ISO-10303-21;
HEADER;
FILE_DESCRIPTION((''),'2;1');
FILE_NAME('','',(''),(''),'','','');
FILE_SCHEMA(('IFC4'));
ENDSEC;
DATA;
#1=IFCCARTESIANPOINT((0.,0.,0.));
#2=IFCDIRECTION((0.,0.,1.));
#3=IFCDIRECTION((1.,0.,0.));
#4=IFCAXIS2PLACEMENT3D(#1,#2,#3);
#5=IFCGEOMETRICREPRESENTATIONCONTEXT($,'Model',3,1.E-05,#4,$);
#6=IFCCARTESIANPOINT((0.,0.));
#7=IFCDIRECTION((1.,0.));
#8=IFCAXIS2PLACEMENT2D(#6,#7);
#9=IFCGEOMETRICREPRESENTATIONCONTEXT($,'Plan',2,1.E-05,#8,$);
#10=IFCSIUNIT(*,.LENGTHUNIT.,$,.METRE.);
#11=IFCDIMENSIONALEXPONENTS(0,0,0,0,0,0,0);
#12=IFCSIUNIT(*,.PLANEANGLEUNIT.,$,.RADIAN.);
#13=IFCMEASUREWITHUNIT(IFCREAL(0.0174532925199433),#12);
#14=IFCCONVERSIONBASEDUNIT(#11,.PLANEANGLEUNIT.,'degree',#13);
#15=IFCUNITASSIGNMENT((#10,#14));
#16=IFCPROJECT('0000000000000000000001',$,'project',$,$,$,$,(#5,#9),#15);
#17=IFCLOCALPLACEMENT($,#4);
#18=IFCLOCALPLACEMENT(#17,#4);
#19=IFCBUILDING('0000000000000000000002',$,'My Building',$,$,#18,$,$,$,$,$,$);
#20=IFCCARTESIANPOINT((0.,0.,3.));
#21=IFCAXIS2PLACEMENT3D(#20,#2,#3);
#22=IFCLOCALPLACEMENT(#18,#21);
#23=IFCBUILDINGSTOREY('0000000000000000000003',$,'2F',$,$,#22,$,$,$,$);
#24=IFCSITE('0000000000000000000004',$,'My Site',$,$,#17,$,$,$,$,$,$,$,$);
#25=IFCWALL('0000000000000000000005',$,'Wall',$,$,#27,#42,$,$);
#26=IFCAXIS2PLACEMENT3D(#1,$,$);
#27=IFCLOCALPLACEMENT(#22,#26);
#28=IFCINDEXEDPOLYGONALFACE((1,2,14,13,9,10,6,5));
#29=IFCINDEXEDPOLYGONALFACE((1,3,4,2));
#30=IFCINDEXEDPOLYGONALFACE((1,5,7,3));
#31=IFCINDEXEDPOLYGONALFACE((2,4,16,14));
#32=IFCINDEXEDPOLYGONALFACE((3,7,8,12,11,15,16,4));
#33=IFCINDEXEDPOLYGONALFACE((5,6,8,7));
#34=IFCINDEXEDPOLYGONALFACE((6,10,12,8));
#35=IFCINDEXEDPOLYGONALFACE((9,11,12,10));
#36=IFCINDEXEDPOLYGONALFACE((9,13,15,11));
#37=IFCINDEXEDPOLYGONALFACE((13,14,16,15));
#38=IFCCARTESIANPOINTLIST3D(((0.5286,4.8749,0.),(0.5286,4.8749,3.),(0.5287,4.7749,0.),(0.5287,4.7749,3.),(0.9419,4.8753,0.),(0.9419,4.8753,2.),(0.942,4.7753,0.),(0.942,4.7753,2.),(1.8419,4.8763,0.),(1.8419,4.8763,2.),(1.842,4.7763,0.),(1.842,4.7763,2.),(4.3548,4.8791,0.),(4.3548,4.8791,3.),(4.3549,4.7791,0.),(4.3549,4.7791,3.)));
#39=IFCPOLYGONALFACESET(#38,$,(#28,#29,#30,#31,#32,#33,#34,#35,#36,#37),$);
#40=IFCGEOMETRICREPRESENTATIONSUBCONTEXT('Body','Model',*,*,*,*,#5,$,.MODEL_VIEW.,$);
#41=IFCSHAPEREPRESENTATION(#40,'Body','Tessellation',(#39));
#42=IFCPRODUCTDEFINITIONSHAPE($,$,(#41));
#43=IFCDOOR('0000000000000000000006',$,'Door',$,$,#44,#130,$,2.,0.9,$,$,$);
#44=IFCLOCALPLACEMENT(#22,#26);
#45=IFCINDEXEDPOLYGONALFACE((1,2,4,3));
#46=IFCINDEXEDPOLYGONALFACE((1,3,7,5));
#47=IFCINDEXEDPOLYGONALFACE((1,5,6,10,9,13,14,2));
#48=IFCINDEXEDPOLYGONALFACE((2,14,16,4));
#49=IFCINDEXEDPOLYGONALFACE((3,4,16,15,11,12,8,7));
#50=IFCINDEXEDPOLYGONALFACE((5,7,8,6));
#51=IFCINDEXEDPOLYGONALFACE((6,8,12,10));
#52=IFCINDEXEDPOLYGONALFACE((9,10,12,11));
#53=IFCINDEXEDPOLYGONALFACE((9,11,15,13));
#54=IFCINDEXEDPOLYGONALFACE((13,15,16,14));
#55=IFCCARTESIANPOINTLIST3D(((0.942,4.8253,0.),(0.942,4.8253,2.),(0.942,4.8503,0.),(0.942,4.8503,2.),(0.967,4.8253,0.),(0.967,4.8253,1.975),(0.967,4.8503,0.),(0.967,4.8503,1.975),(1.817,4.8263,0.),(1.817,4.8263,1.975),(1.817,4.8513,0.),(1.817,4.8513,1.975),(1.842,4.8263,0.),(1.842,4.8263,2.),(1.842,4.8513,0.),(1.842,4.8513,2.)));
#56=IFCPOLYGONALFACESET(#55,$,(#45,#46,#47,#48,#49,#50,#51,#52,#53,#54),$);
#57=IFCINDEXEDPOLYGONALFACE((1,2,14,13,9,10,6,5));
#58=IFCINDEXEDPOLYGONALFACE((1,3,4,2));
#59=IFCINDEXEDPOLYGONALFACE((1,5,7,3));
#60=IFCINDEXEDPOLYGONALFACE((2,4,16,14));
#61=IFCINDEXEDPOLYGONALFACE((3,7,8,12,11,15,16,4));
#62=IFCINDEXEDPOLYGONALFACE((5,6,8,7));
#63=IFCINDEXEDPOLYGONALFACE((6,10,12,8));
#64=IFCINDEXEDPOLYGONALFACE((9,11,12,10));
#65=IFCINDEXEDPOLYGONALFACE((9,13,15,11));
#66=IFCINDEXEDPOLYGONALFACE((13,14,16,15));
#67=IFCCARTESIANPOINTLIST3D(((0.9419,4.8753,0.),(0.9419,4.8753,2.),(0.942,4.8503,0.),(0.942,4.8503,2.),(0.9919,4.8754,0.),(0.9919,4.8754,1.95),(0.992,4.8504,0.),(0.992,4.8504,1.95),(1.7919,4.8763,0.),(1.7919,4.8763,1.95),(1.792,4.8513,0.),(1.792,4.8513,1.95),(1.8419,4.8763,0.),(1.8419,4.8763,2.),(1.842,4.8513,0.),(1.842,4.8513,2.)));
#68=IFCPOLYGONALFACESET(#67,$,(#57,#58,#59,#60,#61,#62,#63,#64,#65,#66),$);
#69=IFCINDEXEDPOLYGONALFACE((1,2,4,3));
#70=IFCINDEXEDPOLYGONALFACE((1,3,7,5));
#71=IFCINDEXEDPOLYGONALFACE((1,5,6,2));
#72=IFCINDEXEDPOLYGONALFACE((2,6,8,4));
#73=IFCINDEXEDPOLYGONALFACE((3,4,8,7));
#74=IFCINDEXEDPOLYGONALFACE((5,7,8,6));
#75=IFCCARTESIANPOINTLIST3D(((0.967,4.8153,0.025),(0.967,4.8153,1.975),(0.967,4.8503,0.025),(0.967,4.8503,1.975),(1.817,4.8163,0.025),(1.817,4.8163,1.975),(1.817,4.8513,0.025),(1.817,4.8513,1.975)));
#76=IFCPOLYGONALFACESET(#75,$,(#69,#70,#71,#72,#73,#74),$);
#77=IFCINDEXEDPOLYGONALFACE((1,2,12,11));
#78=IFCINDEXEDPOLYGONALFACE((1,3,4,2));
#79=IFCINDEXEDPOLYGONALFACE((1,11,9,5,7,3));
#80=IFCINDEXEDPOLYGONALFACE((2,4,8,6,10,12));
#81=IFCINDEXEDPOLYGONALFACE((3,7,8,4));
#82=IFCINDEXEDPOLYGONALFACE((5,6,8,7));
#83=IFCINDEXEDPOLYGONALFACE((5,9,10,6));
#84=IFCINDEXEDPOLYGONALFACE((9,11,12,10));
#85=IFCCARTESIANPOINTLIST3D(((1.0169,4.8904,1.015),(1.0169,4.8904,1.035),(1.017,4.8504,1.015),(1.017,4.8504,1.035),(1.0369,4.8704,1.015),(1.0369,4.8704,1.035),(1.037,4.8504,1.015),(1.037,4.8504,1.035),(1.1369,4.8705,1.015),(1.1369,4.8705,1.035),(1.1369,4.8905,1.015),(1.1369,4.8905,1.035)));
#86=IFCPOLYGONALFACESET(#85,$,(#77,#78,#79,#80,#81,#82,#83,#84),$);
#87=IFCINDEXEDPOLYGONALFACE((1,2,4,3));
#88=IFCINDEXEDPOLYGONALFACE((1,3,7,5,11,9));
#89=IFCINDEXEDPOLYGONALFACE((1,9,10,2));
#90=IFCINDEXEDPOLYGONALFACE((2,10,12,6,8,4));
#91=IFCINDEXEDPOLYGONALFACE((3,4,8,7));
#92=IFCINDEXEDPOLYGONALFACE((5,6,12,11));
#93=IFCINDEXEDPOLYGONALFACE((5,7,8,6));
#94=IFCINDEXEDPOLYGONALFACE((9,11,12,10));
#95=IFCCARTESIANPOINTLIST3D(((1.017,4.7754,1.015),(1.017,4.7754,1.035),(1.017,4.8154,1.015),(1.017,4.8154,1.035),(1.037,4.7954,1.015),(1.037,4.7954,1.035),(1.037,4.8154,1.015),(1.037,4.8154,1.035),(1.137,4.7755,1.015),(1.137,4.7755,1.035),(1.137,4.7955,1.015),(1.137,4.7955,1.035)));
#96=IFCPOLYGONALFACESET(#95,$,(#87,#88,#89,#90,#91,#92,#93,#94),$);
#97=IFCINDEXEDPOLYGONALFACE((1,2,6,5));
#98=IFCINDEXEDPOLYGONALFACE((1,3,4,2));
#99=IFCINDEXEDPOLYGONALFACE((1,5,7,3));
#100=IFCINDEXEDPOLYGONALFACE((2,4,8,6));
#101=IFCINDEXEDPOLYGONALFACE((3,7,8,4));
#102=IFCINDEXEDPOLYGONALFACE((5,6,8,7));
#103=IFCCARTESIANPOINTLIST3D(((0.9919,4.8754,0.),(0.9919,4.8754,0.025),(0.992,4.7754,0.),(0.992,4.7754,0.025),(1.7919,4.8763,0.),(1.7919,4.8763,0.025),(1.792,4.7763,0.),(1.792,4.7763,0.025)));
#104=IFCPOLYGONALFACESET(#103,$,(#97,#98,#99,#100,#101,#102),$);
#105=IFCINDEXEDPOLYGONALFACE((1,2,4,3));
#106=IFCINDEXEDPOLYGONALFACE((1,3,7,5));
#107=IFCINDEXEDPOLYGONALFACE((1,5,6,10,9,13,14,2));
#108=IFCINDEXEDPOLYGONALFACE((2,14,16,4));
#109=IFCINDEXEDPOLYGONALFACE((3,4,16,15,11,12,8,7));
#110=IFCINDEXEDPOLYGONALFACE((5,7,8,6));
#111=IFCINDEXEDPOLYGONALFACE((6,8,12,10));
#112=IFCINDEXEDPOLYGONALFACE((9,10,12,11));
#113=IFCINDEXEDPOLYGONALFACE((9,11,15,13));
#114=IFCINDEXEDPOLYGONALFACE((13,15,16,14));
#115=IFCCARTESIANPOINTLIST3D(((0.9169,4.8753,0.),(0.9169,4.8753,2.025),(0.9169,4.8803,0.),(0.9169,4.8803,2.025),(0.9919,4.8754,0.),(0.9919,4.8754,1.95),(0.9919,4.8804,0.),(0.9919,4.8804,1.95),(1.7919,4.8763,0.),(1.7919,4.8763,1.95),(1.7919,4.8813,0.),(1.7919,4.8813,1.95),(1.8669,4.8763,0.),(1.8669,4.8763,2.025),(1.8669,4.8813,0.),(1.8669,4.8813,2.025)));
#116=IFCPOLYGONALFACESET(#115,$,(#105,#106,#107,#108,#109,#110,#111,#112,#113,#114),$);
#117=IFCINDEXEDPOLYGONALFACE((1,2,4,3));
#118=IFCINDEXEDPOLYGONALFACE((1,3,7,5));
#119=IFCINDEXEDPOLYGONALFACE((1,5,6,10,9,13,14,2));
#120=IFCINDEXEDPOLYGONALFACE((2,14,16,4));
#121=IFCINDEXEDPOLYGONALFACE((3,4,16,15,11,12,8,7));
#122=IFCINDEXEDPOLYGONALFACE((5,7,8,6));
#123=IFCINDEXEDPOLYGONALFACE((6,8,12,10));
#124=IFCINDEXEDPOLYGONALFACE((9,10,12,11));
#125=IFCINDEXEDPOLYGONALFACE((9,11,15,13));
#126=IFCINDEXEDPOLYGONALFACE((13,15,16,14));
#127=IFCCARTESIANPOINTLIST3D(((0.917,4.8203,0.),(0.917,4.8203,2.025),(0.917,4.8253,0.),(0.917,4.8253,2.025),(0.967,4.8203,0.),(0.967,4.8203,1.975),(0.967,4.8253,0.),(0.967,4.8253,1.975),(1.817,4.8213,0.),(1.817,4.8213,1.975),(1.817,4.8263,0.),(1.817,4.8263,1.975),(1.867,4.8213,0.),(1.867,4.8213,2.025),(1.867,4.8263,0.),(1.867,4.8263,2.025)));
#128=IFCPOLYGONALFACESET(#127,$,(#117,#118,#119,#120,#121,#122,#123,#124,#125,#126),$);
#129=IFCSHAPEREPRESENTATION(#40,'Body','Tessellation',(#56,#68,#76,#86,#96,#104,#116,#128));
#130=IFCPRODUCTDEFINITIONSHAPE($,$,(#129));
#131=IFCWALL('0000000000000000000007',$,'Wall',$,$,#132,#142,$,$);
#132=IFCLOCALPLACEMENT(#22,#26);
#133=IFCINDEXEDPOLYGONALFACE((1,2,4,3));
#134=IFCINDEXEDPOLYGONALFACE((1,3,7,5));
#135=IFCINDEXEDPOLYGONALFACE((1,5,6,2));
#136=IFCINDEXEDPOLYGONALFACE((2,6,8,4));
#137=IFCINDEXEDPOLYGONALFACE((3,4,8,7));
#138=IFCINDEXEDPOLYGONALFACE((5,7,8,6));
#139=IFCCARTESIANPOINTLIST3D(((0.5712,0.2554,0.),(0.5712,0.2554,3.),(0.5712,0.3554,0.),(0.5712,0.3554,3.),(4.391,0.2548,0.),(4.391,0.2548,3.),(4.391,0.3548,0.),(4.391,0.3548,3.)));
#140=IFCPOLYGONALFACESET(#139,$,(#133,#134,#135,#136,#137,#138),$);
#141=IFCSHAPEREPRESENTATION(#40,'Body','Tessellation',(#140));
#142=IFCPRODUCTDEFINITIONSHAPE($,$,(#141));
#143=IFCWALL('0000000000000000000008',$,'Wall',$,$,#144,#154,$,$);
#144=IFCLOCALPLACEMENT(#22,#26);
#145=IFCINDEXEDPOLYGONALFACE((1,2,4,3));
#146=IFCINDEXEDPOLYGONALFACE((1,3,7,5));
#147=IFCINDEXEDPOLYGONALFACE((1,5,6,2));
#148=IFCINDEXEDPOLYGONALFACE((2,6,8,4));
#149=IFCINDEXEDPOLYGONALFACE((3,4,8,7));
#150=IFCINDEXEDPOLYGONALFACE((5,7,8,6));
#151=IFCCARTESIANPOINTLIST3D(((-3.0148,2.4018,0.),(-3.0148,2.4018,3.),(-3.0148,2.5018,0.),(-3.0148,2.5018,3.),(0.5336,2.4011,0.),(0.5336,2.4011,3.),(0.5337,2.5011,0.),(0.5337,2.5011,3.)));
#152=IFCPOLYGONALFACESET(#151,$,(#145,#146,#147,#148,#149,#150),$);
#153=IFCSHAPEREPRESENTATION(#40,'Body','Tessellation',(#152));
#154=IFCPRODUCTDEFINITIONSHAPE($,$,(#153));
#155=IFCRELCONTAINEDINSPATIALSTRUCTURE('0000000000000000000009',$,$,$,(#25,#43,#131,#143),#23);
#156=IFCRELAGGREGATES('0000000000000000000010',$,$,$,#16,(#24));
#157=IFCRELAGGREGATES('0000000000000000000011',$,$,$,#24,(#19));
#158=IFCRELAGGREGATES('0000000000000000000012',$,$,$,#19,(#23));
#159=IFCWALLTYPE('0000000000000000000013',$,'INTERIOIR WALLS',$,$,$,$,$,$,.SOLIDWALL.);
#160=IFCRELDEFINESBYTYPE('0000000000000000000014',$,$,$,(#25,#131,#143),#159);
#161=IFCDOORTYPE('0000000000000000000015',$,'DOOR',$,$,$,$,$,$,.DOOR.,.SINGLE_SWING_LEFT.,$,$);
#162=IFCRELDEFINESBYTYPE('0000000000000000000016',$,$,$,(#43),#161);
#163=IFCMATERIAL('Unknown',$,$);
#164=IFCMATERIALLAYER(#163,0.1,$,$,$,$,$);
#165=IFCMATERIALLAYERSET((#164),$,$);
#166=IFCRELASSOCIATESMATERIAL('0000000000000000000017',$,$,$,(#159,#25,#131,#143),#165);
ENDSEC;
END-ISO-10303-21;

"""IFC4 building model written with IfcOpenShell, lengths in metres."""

from ifc_helpers import new_model, entity, si_unit, converted_unit, frame, origin_with_axes, origin_2d_with_axis, place, context, subcontext, project, spatial, line, indexed_curve, outline, extrude, shape, source, transform, mapped, material, layer, layer_set, layer_usage, type_object, type_shapes, element, fill, save


model = new_model("IFC4")

# Units and contexts
model_context = context("Model", 3, precision=1e-05, world=origin_with_axes())
plan_context = context("Plan", 2, precision=1e-05, world=origin_2d_with_axis())
body_context_1 = subcontext(model_context, "Body", "Model", "MODEL_VIEW")
body_context_2 = subcontext(plan_context, "Body", "Plan", "PLAN_VIEW")
ifc_project = project(units=[si_unit("LENGTHUNIT", "METRE"), converted_unit("PLANEANGLEUNIT", "degree", entity("IfcReal", 0.0174532925199433), si_unit("PLANEANGLEUNIT", "RADIAN"), dimensions=[0, 0, 0, 0, 0, 0, 0])], contexts=[model_context, plan_context])

# Site, building, storey
site_placement = place(None, origin_with_axes())
site = spatial("IfcSite", under=ifc_project, at=site_placement, Name="My Site")
building_placement = place(site_placement, origin_with_axes())
building = spatial("IfcBuilding", under=site, at=building_placement, Name="My Building")
storey_placement = place(building_placement, frame((0.0, 0.0, 3.0), z_axis=(0.0, 0.0, 1.0), x_axis=(1.0, 0.0, 0.0)))
storey = spatial("IfcBuildingStorey", under=building, at=storey_placement, Name="2F")

# Shared definitions
ifc_material = material(Name="Unknown")

# Shared definitions
shared_shape_1 = source(origin_with_axes(), body_context_1, "Body", "SweptSolid", [
    extrude(outline(indexed_curve([(0.0, 0.0), (0.9, 0.0), (0.9, 2.0), (0.0, 2.0)], segments=[line(1, 2, 3, 4, 1)])), frame((0.0, -0.6, 0.0), z_axis=(0.0, -1.0, 0.0), x_axis=(1.0, 0.0, 0.0)), (0.0, 0.0, -1.0), 1.2),
])
door_type = type_object("IfcDoorType", Name="DOOR", OperationType="SINGLE_SWING_LEFT", PredefinedType="DOOR")
shared_shape_2 = source(origin_with_axes(), body_context_1, "Body", "SweptSolid", [
    extrude(outline(indexed_curve([(0.0, 0.0), (0.0, 2.0), (0.9, 2.0), (0.9, 0.0), (0.875, 0.0), (0.875, 1.975), (0.025, 1.975), (0.025, 0.0)], segments=[line(1, 2, 3, 4, 5, 6, 7, 8, 1)])), frame((0.0, 0.025, 0.0), z_axis=(0.0, -1.0, 0.0), x_axis=(1.0, 0.0, 0.0)), (0.0, 0.0, -1.0), 0.025),
    extrude(outline(indexed_curve([(0.0, 0.0), (0.0, 2.0), (0.9, 2.0), (0.9, 0.0), (0.85, 0.0), (0.85, 1.95), (0.05, 1.95), (0.05, 0.0)], segments=[line(1, 2, 3, 4, 5, 6, 7, 8, 1)])), frame((0.0, 0.0, 0.0), z_axis=(0.0, -1.0, 0.0), x_axis=(1.0, 0.0, 0.0)), (0.0, 0.0, -1.0), 0.025),
    extrude(outline(indexed_curve([(0.0, 0.0), (0.85, 0.0), (0.85, 0.035), (0.0, 0.035)], segments=[line(1, 2, 3, 4, 1)])), frame((0.025, 0.025, 0.025), z_axis=(0.0, 0.0, 1.0), x_axis=(1.0, 0.0, 0.0)), (0.0, 0.0, 1.0), 1.95),
    extrude(outline(indexed_curve([(0.0, 0.0), (0.0, -0.04), (-0.12, -0.04), (-0.12, -0.02), (-0.02, -0.02), (-0.02, 0.0)], segments=[line(1, 2, 3, 4, 5, 6, 1)])), frame((0.825, 0.025, 1.015), z_axis=(0.0, 0.0, 1.0), x_axis=(1.0, 0.0, 0.0)), (0.0, 0.0, 1.0), 0.02),
    extrude(outline(indexed_curve([(0.0, 0.0), (0.0, 0.04), (-0.12, 0.04), (-0.12, 0.02), (-0.02, 0.02), (-0.02, 0.0)], segments=[line(1, 2, 3, 4, 5, 6, 1)])), frame((0.825, 0.06, 1.015), z_axis=(0.0, 0.0, 1.0), x_axis=(1.0, 0.0, 0.0)), (0.0, 0.0, 1.0), 0.02),
    extrude(outline(indexed_curve([(0.0, 0.0), (0.8, 0.0), (0.8, 0.1), (0.0, 0.1)], segments=[line(1, 2, 3, 4, 1)])), frame((0.05, 0.0, 0.0), z_axis=(0.0, 0.0, 1.0), x_axis=(1.0, 0.0, 0.0)), (0.0, 0.0, 1.0), 0.025),
    extrude(outline(indexed_curve([(0.0, 0.0), (0.0, 2.025), (0.95, 2.025), (0.95, 0.0), (0.875, 0.0), (0.875, 1.95), (0.075, 1.95), (0.075, 0.0)], segments=[line(1, 2, 3, 4, 5, 6, 7, 8, 1)])), frame((-0.025, -0.005, 0.0), z_axis=(0.0, -1.0, 0.0), x_axis=(1.0, 0.0, 0.0)), (0.0, 0.0, -1.0), 0.005),
    extrude(outline(indexed_curve([(0.0, 0.0), (0.0, 2.025), (0.95, 2.025), (0.95, 0.0), (0.9, 0.0), (0.9, 1.975), (0.05, 1.975), (0.05, 0.0)], segments=[line(1, 2, 3, 4, 5, 6, 7, 8, 1)])), frame((-0.025, 0.05, 0.0), z_axis=(0.0, -1.0, 0.0), x_axis=(1.0, 0.0, 0.0)), (0.0, 0.0, -1.0), 0.005),
])
shared_shape_3 = source(origin_with_axes(), body_context_2, "Body", "Curve2D", [
    entity("IfcIndexedPolyCurve", entity("IfcCartesianPointList2D", [[0.0, 0.0], [0.0, 0.05], [0.025, 0.05], [0.025, 0.025], [0.05, 0.025], [0.05, 0.0]]), [entity("IfcLineIndex", [1, 2, 3, 4, 5, 6, 1])]),
    entity("IfcIndexedPolyCurve", entity("IfcCartesianPointList2D", [[0.9, 0.0], [0.9, 0.05], [0.875, 0.05], [0.875, 0.025], [0.85, 0.025], [0.85, 0.0]]), [entity("IfcLineIndex", [1, 2, 3, 4, 5, 6, 1])]),
    entity("IfcTrimmedCurve", entity("IfcEllipse", entity("IfcAxis2Placement2D", entity("IfcCartesianPoint", [0.06, 0.05]), entity("IfcDirection", [1.0, 0.0])), 0.815, 0.85), [entity("IfcCartesianPoint", [0.875, 0.05])], [entity("IfcCartesianPoint", [0.06, 0.9])], True, "CARTESIAN"),
    entity("IfcIndexedPolyCurve", entity("IfcCartesianPointList2D", [[0.025, 0.05], [0.06, 0.05], [0.06, 0.9], [0.025, 0.9]]), [entity("IfcLineIndex", [1, 2, 3, 4, 1])]),
])
type_shapes(door_type, [shared_shape_2, shared_shape_3])

# Shared definitions
ifc_layer_1 = layer(ifc_material, 0.1)
ifc_layer_set_1 = layer_set([ifc_layer_1])
wall_type_1 = type_object("IfcWallType", Name="INTERIOIR WALLS", PredefinedType="SOLIDWALL", material=ifc_layer_set_1)

# Wall, opening, door
ifc_layer_usage_1 = layer_usage(ifc_layer_set_1, "AXIS2", "POSITIVE", 0.0)
wall_1_placement = place(storey_placement, frame((4.3548, 4.8791, 0.0), z_axis=(0.0, 0.0, 1.0), x_axis=(-0.999999, -0.001108, 0.0)))
wall_1 = element("IfcWall", 1, at=wall_1_placement, inside=storey, type_object=wall_type_1, material=ifc_layer_usage_1, Name="Wall", context=body_context_1, shape_type="SweptSolid", body=[
    extrude(outline(indexed_curve([(0.0, 0.0), (0.0, 0.1), (3.8262, 0.1), (3.8262, 0.0)], segments=[line(1, 2, 3, 4, 1)])), origin_with_axes(), (0.0, 0.0, 1.0), 3.0),
])
opening_1_placement = place(wall_1_placement, frame((2.5128, 0.0, 0.0), z_axis=(0.0, 0.0, 1.0), x_axis=(1.0, 0.0, 0.0)))
opening_1 = element("IfcOpeningElement", 2, at=opening_1_placement, cuts=wall_1, PredefinedType="OPENING", context=body_context_1, shape_type="MappedRepresentation", body=[
    mapped(shared_shape_1, transform((0.0, 0.0, 0.0), x_axis=(1.0, 0.0, 0.0), y_axis=(0.0, 1.0, 0.0), z_axis=(0.0, 0.0, 1.0), scale=1.0)),
])
door_1_placement = place(opening_1_placement, frame((0.0, 0.0, 0.0), z_axis=(0.0, 0.0, 1.0), x_axis=(1.0, 0.0, 0.0)))
door_1 = element("IfcDoor", 3, at=door_1_placement, inside=storey, type_object=door_type, Name="Door", OverallHeight=2.0, OverallWidth=0.9, shapes=[
    shape(body_context_1, "Body", "MappedRepresentation", [mapped(shared_shape_2, transform((0.0, 0.0, 0.0), x_axis=(1.0, 0.0, 0.0), y_axis=(0.0, 1.0, 0.0), z_axis=(0.0, 0.0, 1.0), scale=1.0))]),
    shape(body_context_2, "Body", "MappedRepresentation", [mapped(shared_shape_3, transform((0.0, 0.0, 0.0), x_axis=(1.0, 0.0, 0.0), y_axis=(0.0, 1.0, 0.0), z_axis=(0.0, 0.0, 1.0), scale=1.0))]),
])
fill(opening_1, door_1)

# Wall
ifc_layer_usage_2 = layer_usage(ifc_layer_set_1, "AXIS2", "POSITIVE", 0.0)
wall_2_placement = place(storey_placement, frame((4.391, 0.3548, 0.0), z_axis=(0.0, 0.0, 1.0), x_axis=(-1.0, 0.000143, 0.0)))
element("IfcWall", 4, at=wall_2_placement, inside=storey, type_object=wall_type_1, material=ifc_layer_usage_2, Name="Wall", context=body_context_1, shape_type="SweptSolid", body=[
    extrude(outline(indexed_curve([(0.0, 0.0), (0.0, 0.1), (3.8198, 0.1), (3.8198, 0.0)], segments=[line(1, 2, 3, 4, 1)])), origin_with_axes(), (0.0, 0.0, 1.0), 3.0),
])

# Wall
ifc_layer_usage_3 = layer_usage(ifc_layer_set_1, "AXIS2", "POSITIVE", 0.0)
wall_3_placement = place(storey_placement, frame((-3.0148, 2.4018, 0.0), z_axis=(0.0, 0.0, 1.0), x_axis=(1.0, -0.000214, 0.0)))
element("IfcWall", 5, at=wall_3_placement, inside=storey, type_object=wall_type_1, material=ifc_layer_usage_3, Name="Wall", context=body_context_1, shape_type="SweptSolid", body=[
    extrude(outline(indexed_curve([(0.0, 0.0), (0.0, 0.1), (3.5485, 0.1), (3.5485, 0.0)], segments=[line(1, 2, 3, 4, 1)])), origin_with_axes(), (0.0, 0.0, 1.0), 3.0),
])

save(model, "model.ifc")
